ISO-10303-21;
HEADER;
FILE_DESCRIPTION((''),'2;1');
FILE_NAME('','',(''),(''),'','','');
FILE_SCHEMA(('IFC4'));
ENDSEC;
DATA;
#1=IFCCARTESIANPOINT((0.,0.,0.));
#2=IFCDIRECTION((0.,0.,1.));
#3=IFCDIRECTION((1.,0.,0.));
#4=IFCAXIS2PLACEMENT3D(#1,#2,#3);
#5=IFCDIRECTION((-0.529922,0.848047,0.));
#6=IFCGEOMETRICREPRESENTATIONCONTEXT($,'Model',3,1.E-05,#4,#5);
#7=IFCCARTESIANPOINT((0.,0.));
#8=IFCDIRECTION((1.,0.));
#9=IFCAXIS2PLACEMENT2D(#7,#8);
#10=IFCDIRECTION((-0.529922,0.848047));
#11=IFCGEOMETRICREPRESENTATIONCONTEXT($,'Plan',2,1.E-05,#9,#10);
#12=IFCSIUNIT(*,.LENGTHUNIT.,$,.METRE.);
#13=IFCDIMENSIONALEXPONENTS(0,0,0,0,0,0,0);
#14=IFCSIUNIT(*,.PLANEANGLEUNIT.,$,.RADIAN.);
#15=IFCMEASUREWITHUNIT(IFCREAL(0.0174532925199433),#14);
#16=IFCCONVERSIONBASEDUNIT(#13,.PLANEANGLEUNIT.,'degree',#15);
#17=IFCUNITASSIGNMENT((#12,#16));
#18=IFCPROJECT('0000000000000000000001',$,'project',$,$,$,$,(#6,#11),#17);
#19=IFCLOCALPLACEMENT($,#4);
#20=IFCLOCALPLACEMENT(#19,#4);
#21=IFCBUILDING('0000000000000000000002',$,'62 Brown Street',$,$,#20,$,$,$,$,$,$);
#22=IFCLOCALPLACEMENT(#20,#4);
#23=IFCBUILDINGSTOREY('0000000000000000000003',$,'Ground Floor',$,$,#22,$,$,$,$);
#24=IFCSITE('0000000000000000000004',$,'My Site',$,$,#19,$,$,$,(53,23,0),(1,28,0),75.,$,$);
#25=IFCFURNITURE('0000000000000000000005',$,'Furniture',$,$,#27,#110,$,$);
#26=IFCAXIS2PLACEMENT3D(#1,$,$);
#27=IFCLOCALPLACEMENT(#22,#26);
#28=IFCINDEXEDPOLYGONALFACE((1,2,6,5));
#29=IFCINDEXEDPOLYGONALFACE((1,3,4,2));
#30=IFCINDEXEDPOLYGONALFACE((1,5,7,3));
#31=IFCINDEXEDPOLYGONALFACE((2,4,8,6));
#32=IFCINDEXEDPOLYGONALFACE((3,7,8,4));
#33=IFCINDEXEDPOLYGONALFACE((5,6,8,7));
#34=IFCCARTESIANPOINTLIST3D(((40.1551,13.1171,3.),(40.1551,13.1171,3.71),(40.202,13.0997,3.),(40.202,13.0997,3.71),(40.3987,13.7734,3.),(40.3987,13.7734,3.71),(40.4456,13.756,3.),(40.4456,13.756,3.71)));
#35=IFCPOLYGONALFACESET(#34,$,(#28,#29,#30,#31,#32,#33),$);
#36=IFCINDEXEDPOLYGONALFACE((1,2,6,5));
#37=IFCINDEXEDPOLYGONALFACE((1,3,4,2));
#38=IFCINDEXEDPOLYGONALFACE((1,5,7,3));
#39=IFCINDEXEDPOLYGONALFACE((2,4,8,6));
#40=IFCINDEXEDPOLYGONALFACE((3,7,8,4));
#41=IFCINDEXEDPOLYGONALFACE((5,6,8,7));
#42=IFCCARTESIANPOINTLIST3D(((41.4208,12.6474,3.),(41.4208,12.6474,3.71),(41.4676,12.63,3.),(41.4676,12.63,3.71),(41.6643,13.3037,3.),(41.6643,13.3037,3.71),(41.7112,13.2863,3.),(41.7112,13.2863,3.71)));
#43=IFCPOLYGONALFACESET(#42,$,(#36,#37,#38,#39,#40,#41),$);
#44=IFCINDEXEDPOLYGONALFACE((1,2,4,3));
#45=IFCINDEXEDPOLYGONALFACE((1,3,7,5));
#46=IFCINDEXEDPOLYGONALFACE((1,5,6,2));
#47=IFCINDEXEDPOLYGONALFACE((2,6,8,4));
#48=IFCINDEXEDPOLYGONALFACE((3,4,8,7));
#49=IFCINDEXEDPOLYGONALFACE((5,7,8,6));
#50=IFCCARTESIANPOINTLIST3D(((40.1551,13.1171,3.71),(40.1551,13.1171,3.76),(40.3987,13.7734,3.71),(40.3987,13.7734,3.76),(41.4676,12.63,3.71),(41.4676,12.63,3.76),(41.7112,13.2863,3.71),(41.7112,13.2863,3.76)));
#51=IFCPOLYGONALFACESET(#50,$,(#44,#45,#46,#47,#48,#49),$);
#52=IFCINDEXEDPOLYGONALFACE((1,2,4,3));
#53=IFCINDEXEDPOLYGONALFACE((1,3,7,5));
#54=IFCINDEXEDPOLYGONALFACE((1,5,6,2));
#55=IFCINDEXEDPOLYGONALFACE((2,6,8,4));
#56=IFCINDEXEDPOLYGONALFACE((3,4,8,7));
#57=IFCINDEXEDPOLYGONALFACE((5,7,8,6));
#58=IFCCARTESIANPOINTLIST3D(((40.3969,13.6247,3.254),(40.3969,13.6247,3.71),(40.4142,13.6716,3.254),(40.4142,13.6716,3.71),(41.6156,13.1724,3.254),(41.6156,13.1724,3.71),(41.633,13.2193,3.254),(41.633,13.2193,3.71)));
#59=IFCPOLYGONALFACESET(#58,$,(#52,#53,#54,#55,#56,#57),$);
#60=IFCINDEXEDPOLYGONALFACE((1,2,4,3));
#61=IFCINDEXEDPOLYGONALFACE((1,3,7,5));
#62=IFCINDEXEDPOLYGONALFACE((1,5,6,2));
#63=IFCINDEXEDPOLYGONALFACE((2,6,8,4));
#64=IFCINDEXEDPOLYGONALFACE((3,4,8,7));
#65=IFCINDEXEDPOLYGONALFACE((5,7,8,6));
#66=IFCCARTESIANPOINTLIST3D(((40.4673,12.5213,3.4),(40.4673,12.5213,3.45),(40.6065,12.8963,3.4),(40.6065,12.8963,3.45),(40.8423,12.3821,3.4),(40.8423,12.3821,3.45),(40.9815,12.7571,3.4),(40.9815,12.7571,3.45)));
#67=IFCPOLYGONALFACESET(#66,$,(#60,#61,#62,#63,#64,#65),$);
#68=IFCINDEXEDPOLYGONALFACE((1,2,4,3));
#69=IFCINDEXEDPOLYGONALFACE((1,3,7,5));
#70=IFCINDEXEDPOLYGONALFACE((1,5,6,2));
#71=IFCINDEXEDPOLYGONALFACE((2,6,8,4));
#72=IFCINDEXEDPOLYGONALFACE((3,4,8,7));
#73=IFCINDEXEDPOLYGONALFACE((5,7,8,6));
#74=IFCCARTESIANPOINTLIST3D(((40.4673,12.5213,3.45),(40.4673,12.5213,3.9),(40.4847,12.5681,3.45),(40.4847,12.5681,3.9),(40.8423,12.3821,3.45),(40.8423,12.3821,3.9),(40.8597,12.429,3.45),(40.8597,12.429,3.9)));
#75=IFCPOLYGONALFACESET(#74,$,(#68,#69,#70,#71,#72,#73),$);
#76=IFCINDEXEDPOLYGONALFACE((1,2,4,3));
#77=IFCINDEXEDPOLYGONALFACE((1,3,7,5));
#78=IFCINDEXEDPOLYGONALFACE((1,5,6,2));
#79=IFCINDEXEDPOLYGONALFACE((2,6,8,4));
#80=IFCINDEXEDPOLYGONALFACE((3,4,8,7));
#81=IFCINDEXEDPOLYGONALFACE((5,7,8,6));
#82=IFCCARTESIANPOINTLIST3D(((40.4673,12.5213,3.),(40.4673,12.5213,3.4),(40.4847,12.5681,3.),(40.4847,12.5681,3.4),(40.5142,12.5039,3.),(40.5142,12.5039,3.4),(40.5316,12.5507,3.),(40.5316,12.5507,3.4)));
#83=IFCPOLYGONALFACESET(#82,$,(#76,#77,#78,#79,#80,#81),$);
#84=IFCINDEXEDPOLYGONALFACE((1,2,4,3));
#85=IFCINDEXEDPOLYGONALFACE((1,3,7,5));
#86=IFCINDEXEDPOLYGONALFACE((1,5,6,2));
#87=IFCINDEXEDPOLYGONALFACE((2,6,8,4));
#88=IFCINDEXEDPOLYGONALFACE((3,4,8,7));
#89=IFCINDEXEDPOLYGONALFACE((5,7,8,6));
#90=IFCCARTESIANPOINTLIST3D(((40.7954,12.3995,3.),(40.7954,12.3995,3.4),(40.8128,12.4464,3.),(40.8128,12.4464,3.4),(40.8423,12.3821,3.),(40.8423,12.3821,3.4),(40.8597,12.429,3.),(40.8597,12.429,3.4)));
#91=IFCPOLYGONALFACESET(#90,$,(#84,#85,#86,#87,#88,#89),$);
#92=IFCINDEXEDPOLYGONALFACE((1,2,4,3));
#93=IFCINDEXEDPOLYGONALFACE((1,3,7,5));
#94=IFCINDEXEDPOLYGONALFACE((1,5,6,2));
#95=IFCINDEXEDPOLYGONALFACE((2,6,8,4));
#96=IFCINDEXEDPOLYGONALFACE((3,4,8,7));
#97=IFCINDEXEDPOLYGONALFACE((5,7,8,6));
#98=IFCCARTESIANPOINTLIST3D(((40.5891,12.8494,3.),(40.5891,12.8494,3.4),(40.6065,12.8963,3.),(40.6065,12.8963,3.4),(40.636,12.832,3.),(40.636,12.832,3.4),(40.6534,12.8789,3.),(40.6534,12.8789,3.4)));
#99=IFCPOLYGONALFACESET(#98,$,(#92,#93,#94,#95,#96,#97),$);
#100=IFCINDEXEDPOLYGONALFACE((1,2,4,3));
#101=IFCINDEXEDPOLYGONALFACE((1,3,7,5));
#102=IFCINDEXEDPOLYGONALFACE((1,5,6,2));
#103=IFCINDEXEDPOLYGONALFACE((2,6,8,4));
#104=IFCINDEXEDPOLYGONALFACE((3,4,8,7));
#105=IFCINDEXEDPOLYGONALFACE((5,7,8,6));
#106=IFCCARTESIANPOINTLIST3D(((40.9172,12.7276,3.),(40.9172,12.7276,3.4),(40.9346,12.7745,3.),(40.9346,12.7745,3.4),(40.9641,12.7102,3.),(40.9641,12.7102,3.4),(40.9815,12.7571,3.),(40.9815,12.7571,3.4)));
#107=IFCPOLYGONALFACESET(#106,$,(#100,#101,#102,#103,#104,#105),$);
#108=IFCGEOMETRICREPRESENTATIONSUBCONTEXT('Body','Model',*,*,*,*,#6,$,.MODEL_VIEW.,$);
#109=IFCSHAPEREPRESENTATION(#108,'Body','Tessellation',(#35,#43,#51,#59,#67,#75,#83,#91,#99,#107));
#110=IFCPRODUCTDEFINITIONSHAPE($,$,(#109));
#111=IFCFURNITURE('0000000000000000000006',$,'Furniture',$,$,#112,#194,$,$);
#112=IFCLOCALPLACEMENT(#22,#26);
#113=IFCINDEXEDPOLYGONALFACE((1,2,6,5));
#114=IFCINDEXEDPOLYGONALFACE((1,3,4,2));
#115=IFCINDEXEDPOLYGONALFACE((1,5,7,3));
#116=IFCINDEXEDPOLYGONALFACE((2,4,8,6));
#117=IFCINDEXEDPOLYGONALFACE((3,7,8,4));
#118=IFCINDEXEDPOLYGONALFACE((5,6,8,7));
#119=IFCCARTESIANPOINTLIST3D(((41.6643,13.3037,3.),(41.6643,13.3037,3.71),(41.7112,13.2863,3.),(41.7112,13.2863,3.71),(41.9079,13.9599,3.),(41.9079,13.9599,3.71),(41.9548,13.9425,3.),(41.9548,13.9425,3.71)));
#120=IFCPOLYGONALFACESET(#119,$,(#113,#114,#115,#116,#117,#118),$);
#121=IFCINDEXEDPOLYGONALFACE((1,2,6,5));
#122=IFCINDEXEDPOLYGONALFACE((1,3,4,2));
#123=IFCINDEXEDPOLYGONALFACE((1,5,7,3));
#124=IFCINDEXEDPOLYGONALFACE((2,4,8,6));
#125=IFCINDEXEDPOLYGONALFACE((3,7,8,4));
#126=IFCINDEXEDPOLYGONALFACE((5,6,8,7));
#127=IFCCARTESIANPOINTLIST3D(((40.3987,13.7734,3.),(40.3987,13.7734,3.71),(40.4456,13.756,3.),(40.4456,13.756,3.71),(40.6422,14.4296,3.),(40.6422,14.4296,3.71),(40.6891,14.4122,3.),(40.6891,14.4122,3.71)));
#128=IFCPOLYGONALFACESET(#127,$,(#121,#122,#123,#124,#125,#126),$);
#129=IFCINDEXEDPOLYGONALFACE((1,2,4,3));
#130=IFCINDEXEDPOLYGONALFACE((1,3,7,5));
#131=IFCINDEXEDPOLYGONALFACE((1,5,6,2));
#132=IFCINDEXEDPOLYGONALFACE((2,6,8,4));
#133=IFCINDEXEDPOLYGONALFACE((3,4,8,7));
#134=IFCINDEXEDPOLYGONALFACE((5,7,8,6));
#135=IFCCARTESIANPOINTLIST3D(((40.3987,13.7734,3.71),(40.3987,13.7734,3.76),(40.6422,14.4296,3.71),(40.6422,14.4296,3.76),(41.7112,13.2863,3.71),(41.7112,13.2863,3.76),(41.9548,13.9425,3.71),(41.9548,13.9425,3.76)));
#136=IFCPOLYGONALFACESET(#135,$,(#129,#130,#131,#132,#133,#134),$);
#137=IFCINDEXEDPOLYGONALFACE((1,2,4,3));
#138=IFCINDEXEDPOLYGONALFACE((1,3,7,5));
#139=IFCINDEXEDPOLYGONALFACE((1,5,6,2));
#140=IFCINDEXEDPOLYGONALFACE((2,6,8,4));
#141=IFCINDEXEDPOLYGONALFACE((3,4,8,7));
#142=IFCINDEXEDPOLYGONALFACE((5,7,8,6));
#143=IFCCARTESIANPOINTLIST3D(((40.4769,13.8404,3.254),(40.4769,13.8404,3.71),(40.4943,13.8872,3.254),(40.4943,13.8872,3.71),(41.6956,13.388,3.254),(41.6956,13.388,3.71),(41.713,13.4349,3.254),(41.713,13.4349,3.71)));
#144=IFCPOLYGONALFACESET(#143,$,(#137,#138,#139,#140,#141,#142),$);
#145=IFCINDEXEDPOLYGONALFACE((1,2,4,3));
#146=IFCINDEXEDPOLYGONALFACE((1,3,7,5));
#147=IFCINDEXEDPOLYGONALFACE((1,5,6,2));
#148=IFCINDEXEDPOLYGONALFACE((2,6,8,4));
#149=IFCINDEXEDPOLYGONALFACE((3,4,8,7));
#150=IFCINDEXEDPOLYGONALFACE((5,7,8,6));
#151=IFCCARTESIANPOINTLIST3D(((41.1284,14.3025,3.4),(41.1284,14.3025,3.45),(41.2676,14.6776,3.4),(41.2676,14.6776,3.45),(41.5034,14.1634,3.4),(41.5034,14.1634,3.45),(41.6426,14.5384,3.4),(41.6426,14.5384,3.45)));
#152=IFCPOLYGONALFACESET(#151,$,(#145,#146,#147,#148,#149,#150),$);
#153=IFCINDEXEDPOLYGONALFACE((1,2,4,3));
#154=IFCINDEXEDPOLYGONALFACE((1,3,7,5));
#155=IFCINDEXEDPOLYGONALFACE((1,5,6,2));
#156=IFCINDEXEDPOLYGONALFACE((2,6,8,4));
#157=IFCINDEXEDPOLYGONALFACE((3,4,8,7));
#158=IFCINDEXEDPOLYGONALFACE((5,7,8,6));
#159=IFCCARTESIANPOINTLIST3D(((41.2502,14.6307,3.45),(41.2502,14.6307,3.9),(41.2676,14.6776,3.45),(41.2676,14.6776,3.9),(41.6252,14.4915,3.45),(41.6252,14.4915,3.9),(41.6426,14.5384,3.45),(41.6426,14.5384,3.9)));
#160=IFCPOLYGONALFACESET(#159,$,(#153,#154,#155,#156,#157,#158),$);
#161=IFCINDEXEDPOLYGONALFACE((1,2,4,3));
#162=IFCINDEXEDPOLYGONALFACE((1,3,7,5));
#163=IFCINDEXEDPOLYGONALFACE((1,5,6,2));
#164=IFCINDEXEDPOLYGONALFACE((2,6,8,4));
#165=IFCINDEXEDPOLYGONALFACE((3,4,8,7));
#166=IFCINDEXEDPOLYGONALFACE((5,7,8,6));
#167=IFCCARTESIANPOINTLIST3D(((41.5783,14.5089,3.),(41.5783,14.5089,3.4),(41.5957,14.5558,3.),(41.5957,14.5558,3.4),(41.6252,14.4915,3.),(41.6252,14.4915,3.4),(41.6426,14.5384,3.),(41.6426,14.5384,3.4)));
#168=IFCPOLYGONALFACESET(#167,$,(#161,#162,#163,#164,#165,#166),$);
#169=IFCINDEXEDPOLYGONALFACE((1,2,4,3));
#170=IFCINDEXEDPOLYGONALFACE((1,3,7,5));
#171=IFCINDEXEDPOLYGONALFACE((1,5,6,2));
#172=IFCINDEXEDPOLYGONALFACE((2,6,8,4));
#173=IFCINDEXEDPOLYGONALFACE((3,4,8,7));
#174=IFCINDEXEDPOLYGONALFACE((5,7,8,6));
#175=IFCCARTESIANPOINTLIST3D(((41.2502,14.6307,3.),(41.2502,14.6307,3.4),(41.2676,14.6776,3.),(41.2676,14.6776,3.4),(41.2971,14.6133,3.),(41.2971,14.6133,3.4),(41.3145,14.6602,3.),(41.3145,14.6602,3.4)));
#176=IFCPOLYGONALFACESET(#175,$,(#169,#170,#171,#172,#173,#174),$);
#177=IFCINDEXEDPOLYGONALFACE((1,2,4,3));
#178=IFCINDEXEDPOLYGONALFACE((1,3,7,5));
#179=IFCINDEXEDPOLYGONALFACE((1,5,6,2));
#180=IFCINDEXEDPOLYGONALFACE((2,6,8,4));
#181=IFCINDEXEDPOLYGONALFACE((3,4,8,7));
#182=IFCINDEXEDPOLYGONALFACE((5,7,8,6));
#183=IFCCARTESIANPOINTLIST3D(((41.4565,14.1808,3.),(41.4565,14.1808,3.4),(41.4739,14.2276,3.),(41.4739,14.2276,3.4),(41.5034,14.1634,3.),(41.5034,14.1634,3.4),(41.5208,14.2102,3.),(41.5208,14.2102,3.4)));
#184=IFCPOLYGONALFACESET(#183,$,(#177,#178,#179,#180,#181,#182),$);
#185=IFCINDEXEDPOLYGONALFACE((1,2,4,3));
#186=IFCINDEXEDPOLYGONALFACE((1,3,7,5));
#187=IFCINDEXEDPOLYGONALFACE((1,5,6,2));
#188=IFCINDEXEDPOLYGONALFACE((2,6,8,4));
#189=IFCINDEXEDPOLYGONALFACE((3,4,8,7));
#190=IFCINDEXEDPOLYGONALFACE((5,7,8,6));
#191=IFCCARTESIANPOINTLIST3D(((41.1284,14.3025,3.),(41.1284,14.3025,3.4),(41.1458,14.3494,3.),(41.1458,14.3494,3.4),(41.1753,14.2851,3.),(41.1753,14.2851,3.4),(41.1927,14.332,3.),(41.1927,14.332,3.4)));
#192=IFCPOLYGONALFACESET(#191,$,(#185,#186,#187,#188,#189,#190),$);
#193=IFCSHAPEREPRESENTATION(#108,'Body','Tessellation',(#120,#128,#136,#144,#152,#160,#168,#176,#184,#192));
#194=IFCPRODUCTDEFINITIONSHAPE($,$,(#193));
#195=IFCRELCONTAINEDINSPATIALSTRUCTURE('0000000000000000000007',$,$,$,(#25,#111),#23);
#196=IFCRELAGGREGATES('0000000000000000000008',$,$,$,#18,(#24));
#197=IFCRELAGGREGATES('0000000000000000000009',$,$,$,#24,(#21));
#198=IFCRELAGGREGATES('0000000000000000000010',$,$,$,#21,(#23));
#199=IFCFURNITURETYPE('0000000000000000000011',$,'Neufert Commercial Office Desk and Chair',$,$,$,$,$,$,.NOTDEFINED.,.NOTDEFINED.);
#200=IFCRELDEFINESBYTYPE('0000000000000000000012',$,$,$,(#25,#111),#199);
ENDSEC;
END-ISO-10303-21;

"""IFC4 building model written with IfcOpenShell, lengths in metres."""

from ifc_helpers import new_model, entity, si_unit, converted_unit, direction, frame, origin_with_axes, origin_2d_with_axis, place, context, subcontext, project, spatial, line, indexed_curve, outline, extrude, shape, source, transform, mapped, type_object, type_shapes, element, save


model = new_model("IFC4")

# Units and contexts
model_context = context("Model", 3, precision=1e-05, world=origin_with_axes(), true_north=direction((-0.529922, 0.848047, 0.0)))
plan_context = context("Plan", 2, precision=1e-05, world=origin_2d_with_axis(), true_north=direction((-0.529922, 0.848047)))
body_context_1 = subcontext(model_context, "Body", "Model", "MODEL_VIEW")
body_context_2 = subcontext(plan_context, "Body", "Plan", "PLAN_VIEW")
ifc_project = project(units=[si_unit("LENGTHUNIT", "METRE"), converted_unit("PLANEANGLEUNIT", "degree", entity("IfcReal", 0.0174532925199433), si_unit("PLANEANGLEUNIT", "RADIAN"), dimensions=[0, 0, 0, 0, 0, 0, 0])], contexts=[model_context, plan_context])

# Site, building, storey
site_placement = place(None, origin_with_axes())
site = spatial("IfcSite", under=ifc_project, at=site_placement, Name="My Site", RefLatitude=(53, 23, 0), RefLongitude=(1, 28, 0), RefElevation=75.0)
building_placement = place(site_placement, origin_with_axes())
building = spatial("IfcBuilding", under=site, at=building_placement, Name="62 Brown Street")
storey_placement = place(building_placement, origin_with_axes())
storey = spatial("IfcBuildingStorey", under=building, at=storey_placement, Name="Ground Floor")

# Furniture
furniture_type = type_object("IfcFurnitureType", Name="Neufert Commercial Office Desk and Chair", AssemblyPlace="NOTDEFINED", PredefinedType="NOTDEFINED")
shared_shape_1 = source(origin_with_axes(), body_context_1, "Body", "SweptSolid", [
    extrude(outline(indexed_curve([(0.0, 0.0), (0.05, 0.0), (0.05, 0.7), (0.0, 0.7)], segments=[line(1, 2, 3, 4, 1)])), frame((0.0, 0.45, 0.0), z_axis=(0.0, 0.0, 1.0), x_axis=(1.0, 0.0, 0.0)), (0.0, 0.0, 1.0), 0.71),
    extrude(outline(indexed_curve([(0.0, 0.0), (0.05, 0.0), (0.05, 0.7), (0.0, 0.7)], segments=[line(1, 2, 3, 4, 1)])), frame((1.35, 0.45, 0.0), z_axis=(0.0, 0.0, 1.0), x_axis=(1.0, 0.0, 0.0)), (0.0, 0.0, 1.0), 0.71),
    extrude(outline(indexed_curve([(0.0, 0.0), (1.4, 0.0), (1.4, 0.7), (0.0, 0.7)], segments=[line(1, 2, 3, 4, 1)])), frame((0.0, 0.45, 0.71), z_axis=(0.0, 0.0, 1.0), x_axis=(1.0, 0.0, 0.0)), (0.0, 0.0, 1.0), 0.05),
    extrude(outline(indexed_curve([(0.05, 0.56), (1.35, 0.56), (1.35, 0.61), (0.05, 0.61)], segments=[line(1, 2, 3, 4, 1)])), frame((0.0, 0.45, 0.254), z_axis=(0.0, 0.0, 1.0), x_axis=(1.0, 0.0, 0.0)), (0.0, 0.0, 1.0), 0.456),
    extrude(outline(indexed_curve([(-0.2, 0.0), (0.2, 0.0), (0.2, 0.4), (-0.2, 0.4)], segments=[line(1, 2, 3, 4, 1)])), frame((0.7, 0.0, 0.45), z_axis=(0.0, 0.0, 1.0), x_axis=(1.0, 0.0, 0.0)), (0.0, 0.0, -1.0), 0.05),
    extrude(outline(indexed_curve([(-0.2, 0.0), (0.2, 0.0), (0.2, 0.05), (-0.2, 0.05)], segments=[line(1, 2, 3, 4, 1)])), frame((0.7, 0.0, 0.9), z_axis=(0.0, 0.0, 1.0), x_axis=(1.0, 0.0, 0.0)), (0.0, 0.0, -1.0), 0.45),
    extrude(outline(indexed_curve([(-0.2, 0.0), (-0.15, 0.0), (-0.15, 0.05), (-0.2, 0.05)], segments=[line(1, 2, 3, 4, 1)])), frame((0.7, 0.0, 0.0), z_axis=(0.0, 0.0, 1.0), x_axis=(1.0, 0.0, 0.0)), (0.0, 0.0, 1.0), 0.4),
    extrude(outline(indexed_curve([(0.2, 0.0), (0.15, 0.0), (0.15, 0.05), (0.2, 0.05)], segments=[line(1, 2, 3, 4, 1)])), frame((0.7, 0.0, 0.0), z_axis=(0.0, 0.0, 1.0), x_axis=(1.0, 0.0, 0.0)), (0.0, 0.0, 1.0), 0.4),
    extrude(outline(indexed_curve([(-0.2, 0.4), (-0.15, 0.4), (-0.15, 0.35), (-0.2, 0.35)], segments=[line(1, 2, 3, 4, 1)])), frame((0.7, 0.0, 0.0), z_axis=(0.0, 0.0, 1.0), x_axis=(1.0, 0.0, 0.0)), (0.0, 0.0, 1.0), 0.4),
    extrude(outline(indexed_curve([(0.2, 0.4), (0.15, 0.4), (0.15, 0.35), (0.2, 0.35)], segments=[line(1, 2, 3, 4, 1)])), frame((0.7, 0.0, 0.0), z_axis=(0.0, 0.0, 1.0), x_axis=(1.0, 0.0, 0.0)), (0.0, 0.0, 1.0), 0.4),
])
shared_shape_2 = source(origin_with_axes(), body_context_2, "Body", "Curve2D", [
    entity("IfcIndexedPolyCurve", entity("IfcCartesianPointList2D", [[0.0, 0.45], [1.4, 0.45], [1.4, 1.15], [0.0, 1.15]]), [entity("IfcLineIndex", [1, 2, 3, 4, 1])]),
    entity("IfcIndexedPolyCurve", entity("IfcCartesianPointList2D", [[0.5, 0.4], [0.9, 0.4]])),
    entity("IfcIndexedPolyCurve", entity("IfcCartesianPointList2D", [[0.5, 0.4], [0.5, 0.2], [0.5586, 0.0586], [0.7, 0.0], [0.8414, 0.0586], [0.9, 0.2], [0.9, 0.4]]), [entity("IfcLineIndex", [1, 2]), entity("IfcArcIndex", [2, 3, 4]), entity("IfcArcIndex", [4, 5, 6]), entity("IfcLineIndex", [6, 7])]),
    entity("IfcIndexedPolyCurve", entity("IfcCartesianPointList2D", [[0.54, 0.4], [0.54, 0.2], [0.5869, 0.0869], [0.7, 0.04], [0.8131, 0.0869], [0.86, 0.2], [0.86, 0.4]]), [entity("IfcLineIndex", [1, 2]), entity("IfcArcIndex", [2, 3, 4]), entity("IfcArcIndex", [4, 5, 6]), entity("IfcLineIndex", [6, 7])]),
])
type_shapes(furniture_type, [shared_shape_1, shared_shape_2])
for number, where, z_axis, x_axis, name in (
    (1, (39.9986, 12.6952, 3.0), (0.0, 0.0, 1.0), (0.937515, -0.347944, 0.0), "Furniture"),
    (2, (42.1113, 14.3644, 3.0), (0.0, 0.0, 1.0), (-0.937515, 0.347945, 0.0), "Furniture"),
):
    element("IfcFurniture", number, at=place(storey_placement, frame(where, z_axis=z_axis, x_axis=x_axis)), inside=storey, type_object=furniture_type, Name=name, shapes=[
        shape(body_context_1, "Body", "MappedRepresentation", [mapped(shared_shape_1, transform((0.0, 0.0, 0.0), x_axis=(1.0, 0.0, 0.0), y_axis=(0.0, 1.0, 0.0), z_axis=(0.0, 0.0, 1.0), scale=1.0))]),
        shape(body_context_2, "Body", "MappedRepresentation", [mapped(shared_shape_2, transform((0.0, 0.0, 0.0), x_axis=(1.0, 0.0, 0.0), y_axis=(0.0, 1.0, 0.0), z_axis=(0.0, 0.0, 1.0), scale=1.0))]),
    ])

save(model, "model.ifc")
